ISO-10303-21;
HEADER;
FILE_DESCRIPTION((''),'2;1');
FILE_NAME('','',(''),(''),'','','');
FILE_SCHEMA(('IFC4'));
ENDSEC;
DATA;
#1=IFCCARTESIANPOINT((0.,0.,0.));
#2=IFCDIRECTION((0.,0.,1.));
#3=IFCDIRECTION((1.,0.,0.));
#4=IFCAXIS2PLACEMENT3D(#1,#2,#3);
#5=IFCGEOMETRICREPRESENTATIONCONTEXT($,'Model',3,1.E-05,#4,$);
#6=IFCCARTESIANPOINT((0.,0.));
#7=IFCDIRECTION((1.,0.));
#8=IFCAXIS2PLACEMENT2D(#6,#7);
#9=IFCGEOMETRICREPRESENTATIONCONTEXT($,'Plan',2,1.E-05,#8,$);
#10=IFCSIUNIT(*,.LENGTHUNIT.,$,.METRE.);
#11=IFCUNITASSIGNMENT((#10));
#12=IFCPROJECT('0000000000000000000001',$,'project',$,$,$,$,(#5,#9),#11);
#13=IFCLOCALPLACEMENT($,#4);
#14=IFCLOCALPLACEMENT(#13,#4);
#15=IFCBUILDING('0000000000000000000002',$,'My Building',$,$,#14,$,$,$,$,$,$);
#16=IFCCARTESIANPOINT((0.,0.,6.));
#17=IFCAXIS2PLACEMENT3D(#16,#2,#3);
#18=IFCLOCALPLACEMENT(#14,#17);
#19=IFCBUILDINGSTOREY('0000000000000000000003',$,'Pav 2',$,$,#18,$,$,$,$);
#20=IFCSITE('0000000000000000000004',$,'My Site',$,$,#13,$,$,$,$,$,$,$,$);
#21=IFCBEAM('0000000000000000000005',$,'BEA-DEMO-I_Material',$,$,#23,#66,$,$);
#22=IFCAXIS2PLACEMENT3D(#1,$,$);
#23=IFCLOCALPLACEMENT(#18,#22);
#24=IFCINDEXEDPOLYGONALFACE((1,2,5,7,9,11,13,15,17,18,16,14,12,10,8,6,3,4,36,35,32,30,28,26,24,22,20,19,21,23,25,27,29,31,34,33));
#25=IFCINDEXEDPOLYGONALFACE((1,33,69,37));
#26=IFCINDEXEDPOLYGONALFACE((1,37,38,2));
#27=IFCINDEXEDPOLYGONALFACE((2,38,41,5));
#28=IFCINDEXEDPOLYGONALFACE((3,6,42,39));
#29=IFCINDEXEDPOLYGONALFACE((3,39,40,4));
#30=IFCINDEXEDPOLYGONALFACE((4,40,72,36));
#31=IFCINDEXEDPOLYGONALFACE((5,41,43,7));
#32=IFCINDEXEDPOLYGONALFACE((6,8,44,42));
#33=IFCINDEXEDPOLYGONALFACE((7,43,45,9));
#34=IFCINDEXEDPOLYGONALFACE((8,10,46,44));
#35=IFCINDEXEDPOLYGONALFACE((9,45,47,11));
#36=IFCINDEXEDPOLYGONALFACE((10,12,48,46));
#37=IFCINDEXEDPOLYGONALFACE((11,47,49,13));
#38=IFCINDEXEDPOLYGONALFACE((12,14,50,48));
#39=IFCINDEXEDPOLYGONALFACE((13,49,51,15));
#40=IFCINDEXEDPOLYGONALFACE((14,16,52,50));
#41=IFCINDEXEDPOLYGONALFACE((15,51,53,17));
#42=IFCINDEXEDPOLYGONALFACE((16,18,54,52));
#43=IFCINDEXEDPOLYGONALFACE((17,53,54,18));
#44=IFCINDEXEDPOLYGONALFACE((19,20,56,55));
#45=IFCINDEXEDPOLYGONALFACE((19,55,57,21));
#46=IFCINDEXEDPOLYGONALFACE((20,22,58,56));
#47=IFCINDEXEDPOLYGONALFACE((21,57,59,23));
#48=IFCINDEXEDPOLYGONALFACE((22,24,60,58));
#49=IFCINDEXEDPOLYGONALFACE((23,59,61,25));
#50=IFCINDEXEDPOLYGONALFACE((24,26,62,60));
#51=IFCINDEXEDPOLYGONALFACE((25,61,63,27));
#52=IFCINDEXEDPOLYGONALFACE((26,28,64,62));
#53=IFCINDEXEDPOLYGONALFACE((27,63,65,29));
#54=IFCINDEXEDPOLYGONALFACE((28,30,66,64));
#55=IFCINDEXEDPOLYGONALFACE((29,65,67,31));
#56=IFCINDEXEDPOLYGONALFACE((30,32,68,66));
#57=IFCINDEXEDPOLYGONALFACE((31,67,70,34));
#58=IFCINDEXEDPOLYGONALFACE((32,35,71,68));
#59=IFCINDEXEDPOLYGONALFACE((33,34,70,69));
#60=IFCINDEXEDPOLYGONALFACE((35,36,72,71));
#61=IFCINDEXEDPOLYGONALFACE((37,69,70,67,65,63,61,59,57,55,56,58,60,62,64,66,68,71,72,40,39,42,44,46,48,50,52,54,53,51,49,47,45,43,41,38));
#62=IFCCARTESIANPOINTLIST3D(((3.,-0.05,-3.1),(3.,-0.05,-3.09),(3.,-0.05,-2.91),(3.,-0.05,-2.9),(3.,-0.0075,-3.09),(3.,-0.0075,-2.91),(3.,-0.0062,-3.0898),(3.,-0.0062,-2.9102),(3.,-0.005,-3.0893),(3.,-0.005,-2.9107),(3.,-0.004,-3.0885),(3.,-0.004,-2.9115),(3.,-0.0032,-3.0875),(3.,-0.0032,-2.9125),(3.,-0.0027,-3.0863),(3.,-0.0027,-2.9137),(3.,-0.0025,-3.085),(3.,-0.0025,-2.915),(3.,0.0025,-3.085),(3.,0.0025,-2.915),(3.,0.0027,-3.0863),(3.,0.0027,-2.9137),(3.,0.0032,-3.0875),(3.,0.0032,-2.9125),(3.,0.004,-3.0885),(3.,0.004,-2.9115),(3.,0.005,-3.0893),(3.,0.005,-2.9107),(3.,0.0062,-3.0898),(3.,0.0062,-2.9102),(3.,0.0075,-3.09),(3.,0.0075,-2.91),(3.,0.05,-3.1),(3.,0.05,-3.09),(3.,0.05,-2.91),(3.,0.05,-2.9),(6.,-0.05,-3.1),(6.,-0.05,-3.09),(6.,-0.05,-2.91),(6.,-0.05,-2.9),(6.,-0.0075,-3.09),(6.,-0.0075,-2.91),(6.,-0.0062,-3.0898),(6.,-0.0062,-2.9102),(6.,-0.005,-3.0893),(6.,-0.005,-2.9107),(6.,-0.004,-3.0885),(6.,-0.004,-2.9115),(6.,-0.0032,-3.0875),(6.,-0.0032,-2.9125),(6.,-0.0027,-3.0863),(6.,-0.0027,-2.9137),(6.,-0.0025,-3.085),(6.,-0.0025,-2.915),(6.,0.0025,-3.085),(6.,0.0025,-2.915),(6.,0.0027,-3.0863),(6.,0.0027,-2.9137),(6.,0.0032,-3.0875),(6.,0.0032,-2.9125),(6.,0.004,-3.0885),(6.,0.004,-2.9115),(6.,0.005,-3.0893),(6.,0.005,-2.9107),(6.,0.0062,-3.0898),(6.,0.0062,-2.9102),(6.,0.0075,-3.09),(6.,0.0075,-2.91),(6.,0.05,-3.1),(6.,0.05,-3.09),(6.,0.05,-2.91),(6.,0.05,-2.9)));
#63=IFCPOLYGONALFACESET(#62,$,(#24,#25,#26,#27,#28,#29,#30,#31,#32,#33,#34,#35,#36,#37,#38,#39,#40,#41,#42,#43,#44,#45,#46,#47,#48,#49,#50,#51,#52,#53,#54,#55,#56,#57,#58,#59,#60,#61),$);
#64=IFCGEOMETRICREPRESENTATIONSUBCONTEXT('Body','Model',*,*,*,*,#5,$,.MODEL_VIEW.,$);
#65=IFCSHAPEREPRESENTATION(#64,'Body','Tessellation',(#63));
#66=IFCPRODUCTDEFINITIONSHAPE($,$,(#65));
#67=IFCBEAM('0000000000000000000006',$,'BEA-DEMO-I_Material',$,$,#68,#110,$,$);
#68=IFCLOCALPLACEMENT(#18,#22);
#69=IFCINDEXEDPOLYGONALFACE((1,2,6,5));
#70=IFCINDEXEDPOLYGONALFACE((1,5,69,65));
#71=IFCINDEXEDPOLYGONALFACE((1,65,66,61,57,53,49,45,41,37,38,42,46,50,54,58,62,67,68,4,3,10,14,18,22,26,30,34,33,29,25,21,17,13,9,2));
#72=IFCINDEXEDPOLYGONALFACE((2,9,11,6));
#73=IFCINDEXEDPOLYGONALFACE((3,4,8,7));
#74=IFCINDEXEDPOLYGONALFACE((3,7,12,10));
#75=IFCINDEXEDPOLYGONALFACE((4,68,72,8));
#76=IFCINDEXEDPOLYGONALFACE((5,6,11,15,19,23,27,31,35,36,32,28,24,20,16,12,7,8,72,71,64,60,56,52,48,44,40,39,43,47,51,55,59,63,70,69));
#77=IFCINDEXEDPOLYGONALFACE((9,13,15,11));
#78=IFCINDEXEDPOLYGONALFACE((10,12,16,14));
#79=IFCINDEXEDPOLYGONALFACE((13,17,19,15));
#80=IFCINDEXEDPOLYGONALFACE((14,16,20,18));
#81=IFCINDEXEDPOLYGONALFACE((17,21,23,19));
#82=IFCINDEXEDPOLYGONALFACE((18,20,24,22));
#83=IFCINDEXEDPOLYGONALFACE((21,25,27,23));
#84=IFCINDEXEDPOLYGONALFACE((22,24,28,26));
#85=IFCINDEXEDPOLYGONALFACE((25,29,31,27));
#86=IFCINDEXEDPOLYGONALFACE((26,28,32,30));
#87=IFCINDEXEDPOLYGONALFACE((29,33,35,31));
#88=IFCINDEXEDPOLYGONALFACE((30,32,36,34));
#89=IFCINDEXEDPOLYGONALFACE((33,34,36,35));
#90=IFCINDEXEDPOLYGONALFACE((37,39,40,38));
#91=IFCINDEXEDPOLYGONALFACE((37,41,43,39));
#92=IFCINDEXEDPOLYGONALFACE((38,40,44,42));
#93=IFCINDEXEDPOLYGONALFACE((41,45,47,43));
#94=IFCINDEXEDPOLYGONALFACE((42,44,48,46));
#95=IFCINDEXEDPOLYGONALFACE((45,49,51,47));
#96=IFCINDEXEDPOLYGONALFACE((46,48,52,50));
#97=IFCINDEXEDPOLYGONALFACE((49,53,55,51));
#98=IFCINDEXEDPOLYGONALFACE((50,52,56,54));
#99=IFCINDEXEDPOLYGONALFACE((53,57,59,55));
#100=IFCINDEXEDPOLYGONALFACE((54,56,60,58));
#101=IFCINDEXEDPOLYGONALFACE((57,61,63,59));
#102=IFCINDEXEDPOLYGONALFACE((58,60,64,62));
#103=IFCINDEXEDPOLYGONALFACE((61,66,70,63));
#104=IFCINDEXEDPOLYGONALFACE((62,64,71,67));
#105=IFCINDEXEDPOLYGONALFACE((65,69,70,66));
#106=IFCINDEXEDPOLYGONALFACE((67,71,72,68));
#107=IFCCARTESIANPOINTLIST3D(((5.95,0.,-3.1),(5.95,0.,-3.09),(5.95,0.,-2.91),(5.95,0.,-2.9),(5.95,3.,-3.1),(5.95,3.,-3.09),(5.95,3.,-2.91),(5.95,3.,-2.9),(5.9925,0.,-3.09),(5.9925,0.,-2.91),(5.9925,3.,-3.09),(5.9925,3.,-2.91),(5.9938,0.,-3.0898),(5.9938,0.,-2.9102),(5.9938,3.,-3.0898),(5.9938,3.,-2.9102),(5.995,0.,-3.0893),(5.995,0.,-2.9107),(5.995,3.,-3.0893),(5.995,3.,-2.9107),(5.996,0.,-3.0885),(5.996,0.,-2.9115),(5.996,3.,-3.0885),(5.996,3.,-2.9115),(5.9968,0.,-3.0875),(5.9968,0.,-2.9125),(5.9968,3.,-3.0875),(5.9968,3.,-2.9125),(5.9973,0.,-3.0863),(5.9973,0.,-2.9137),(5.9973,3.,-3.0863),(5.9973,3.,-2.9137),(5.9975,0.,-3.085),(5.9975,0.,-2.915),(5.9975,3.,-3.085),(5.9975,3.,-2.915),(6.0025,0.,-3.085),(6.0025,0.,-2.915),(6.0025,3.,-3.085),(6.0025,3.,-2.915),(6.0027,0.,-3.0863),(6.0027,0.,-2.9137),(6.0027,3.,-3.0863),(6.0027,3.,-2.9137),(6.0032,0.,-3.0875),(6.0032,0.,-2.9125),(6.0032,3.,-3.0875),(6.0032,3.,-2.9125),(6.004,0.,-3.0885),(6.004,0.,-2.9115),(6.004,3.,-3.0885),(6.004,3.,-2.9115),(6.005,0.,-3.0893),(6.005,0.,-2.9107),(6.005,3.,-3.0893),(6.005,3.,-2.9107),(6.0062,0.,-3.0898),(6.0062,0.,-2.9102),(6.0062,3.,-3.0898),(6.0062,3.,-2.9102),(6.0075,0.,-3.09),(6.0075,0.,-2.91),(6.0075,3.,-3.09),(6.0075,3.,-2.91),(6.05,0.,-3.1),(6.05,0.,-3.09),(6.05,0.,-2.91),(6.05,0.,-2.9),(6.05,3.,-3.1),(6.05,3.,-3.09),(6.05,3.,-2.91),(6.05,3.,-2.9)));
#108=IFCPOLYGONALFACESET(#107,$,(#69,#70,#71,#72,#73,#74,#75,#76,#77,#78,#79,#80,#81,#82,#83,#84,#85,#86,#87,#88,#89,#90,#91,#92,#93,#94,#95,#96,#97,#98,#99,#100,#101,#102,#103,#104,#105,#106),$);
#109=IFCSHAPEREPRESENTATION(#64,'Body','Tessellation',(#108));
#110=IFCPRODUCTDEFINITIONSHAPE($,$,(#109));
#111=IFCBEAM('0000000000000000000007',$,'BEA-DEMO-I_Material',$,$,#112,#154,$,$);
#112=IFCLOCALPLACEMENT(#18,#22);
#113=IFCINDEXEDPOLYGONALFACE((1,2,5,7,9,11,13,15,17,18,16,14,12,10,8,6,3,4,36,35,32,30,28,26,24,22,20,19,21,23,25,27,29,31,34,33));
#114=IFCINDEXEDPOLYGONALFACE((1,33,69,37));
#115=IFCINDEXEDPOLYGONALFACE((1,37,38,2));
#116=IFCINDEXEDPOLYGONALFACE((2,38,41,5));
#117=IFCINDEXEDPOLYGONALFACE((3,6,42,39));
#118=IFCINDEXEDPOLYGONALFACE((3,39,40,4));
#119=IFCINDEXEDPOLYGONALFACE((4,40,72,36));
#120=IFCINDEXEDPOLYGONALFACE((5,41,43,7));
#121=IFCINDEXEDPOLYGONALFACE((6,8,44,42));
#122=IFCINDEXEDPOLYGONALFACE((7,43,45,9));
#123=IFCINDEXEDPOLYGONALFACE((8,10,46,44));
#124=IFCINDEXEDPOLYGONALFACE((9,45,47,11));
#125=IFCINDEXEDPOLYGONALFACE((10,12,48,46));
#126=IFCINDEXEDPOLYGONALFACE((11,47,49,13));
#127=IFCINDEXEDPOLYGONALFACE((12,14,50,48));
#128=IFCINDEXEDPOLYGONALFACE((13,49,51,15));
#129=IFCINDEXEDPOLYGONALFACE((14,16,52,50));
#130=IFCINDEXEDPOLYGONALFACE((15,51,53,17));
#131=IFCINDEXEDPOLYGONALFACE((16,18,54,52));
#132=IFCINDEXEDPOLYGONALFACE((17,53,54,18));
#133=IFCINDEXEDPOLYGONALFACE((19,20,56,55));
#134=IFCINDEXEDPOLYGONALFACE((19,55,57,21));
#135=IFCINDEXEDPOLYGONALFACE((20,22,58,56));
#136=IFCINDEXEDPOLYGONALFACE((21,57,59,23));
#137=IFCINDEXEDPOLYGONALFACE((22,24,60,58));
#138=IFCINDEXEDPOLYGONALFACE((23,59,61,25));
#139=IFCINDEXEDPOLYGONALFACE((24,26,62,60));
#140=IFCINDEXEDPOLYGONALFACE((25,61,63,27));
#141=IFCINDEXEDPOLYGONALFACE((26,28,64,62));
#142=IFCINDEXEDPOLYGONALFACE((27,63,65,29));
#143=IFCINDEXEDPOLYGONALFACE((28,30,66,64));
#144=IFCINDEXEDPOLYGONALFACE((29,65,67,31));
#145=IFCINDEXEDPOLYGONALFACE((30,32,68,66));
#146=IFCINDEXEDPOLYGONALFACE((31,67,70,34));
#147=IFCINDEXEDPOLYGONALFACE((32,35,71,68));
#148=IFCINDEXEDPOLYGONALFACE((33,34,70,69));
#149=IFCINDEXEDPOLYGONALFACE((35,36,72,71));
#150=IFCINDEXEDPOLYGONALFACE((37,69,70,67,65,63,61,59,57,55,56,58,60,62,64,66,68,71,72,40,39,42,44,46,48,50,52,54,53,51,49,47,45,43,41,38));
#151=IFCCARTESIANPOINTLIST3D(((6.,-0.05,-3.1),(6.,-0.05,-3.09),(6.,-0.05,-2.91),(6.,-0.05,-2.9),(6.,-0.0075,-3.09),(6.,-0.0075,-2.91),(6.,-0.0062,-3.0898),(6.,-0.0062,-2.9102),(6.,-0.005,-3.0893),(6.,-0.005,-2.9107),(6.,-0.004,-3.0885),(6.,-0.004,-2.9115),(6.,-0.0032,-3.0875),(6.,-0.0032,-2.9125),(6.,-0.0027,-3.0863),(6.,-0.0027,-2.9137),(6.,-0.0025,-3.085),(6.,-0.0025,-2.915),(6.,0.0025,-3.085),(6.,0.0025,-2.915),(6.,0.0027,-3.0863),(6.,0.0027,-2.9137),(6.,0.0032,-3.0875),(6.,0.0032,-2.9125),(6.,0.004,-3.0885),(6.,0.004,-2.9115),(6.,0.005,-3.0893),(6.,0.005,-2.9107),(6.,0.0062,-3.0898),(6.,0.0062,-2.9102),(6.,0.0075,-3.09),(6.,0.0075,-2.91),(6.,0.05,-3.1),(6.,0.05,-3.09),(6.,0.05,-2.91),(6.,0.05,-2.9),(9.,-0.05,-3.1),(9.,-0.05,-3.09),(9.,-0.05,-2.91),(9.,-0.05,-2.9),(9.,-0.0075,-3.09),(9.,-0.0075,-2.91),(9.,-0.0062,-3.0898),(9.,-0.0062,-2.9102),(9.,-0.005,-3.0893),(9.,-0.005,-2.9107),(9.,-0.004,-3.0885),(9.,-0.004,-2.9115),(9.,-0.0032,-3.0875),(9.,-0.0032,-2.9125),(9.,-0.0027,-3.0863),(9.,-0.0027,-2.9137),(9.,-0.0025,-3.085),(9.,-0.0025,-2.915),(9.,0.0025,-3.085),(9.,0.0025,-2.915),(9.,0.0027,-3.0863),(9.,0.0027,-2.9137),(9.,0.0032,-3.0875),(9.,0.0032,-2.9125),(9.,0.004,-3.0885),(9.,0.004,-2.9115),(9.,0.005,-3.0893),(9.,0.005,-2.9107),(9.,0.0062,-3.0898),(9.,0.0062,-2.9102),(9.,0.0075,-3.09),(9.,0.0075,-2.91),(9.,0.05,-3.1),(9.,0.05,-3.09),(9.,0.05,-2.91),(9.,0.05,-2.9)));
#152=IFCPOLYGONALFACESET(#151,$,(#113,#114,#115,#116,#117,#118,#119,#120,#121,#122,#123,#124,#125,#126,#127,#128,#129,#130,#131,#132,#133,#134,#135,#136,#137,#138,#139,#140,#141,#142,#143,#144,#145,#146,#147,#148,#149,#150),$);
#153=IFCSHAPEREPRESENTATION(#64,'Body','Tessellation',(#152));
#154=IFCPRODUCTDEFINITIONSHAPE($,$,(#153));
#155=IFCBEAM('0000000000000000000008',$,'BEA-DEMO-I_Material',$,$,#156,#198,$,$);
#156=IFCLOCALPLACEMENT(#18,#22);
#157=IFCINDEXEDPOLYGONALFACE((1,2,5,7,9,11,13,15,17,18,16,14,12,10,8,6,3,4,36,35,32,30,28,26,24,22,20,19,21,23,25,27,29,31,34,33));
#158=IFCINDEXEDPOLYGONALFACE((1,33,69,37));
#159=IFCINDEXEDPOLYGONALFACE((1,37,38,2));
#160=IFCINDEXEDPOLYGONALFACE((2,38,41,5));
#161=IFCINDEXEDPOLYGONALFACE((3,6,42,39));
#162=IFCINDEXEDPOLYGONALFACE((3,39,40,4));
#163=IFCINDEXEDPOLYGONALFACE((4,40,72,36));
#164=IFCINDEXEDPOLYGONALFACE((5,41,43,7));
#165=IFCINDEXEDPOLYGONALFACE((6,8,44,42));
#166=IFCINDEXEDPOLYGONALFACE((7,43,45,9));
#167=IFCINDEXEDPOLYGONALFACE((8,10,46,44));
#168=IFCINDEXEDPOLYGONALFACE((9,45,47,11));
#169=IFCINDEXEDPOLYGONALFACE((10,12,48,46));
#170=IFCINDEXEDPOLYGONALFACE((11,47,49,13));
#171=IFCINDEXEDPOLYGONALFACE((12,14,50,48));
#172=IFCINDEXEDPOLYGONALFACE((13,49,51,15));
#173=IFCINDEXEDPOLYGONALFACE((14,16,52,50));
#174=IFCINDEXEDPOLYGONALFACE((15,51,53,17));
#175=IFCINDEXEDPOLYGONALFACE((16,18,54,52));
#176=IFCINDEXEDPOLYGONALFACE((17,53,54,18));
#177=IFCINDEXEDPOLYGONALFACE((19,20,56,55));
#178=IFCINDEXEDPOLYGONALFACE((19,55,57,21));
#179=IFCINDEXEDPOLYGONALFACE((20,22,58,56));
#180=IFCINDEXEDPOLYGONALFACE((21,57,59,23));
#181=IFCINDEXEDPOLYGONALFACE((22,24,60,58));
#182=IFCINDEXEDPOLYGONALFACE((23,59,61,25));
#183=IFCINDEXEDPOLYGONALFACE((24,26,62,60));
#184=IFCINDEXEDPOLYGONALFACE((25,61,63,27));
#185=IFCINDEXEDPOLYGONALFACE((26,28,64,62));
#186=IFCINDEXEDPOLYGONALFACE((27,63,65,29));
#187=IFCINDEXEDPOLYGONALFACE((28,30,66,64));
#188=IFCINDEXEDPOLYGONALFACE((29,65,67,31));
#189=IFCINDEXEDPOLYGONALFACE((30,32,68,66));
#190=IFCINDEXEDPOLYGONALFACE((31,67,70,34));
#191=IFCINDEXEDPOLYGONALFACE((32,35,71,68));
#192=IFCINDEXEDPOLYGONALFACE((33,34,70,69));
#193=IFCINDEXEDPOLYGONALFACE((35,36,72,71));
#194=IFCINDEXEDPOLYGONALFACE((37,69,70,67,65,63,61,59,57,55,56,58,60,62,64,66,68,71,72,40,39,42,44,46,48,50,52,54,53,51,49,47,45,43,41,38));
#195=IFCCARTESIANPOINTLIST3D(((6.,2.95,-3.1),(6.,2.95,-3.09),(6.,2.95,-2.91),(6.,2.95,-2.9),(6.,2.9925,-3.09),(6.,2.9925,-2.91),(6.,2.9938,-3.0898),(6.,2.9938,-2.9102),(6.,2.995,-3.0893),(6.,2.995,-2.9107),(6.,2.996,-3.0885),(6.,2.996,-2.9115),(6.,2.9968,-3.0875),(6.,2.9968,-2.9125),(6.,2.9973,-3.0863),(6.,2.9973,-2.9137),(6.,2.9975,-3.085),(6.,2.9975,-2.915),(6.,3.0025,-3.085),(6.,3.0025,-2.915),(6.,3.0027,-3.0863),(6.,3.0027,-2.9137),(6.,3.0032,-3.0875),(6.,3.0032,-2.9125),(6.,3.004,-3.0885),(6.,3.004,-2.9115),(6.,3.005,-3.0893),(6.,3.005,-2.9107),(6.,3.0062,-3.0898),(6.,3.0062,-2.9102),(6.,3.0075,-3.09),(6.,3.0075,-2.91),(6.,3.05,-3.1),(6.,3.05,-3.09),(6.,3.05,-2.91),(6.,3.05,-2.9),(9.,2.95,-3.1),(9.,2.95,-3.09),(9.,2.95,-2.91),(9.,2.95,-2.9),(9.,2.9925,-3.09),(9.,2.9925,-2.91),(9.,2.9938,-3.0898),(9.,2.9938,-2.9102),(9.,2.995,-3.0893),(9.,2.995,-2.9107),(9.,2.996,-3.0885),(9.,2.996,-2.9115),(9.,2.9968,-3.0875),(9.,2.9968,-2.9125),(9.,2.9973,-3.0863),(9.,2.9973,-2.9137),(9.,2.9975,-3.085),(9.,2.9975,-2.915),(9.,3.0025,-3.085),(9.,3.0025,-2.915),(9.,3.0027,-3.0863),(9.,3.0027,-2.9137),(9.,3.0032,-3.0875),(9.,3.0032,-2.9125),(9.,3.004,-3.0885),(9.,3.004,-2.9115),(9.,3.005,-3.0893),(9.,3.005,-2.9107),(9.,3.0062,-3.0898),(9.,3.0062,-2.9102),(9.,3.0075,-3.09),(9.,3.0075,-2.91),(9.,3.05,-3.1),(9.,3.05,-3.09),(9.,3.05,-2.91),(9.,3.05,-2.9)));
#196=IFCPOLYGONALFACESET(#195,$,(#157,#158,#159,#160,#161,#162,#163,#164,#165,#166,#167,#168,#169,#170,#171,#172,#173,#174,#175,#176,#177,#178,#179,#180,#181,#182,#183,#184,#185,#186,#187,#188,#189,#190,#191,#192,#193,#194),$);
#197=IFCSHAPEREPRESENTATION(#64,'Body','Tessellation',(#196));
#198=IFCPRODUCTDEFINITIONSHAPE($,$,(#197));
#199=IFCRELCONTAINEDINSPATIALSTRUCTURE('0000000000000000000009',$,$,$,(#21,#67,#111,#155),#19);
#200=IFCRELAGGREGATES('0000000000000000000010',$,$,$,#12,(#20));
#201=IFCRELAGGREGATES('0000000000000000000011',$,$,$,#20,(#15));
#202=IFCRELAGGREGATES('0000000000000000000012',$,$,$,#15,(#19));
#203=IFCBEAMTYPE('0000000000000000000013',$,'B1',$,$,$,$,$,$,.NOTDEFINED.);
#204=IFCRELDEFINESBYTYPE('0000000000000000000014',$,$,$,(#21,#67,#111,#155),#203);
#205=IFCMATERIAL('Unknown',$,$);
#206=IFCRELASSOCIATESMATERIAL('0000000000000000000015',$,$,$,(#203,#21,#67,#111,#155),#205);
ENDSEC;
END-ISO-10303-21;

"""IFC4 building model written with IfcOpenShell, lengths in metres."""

from ifc_helpers import new_model, si_unit, frame, origin, origin_with_axes, origin_2d_with_axis, place, context, subcontext, project, spatial, i_section, extrude, material, material_profile, profile_set, profile_usage, type_object, element, save


model = new_model("IFC4")

# Units and contexts
model_context = context("Model", 3, precision=1e-05, world=origin_with_axes())
plan_context = context("Plan", 2, precision=1e-05, world=origin_2d_with_axis())
body_context = subcontext(model_context, "Body", "Model", "MODEL_VIEW")
ifc_project = project(units=[si_unit("LENGTHUNIT", "METRE")], contexts=[model_context, plan_context])

# Site, building, storey
site_placement = place(None, origin_with_axes())
site = spatial("IfcSite", under=ifc_project, at=site_placement, Name="My Site")
building_placement = place(site_placement, origin_with_axes())
building = spatial("IfcBuilding", under=site, at=building_placement, Name="My Building")
storey_placement = place(building_placement, frame((0.0, 0.0, 6.0), z_axis=(0.0, 0.0, 1.0), x_axis=(1.0, 0.0, 0.0)))
storey = spatial("IfcBuildingStorey", under=building, at=storey_placement, Name="Pav 2")

# Beams
ifc_material = material(Name="Unknown")
ifc_material_profile = material_profile(ifc_material, i_section(OverallWidth=0.1, OverallDepth=0.2, WebThickness=0.005, FlangeThickness=0.01, FilletRadius=0.005))
ifc_profile_set = profile_set([ifc_material_profile])
ifc_profile_usage_1 = profile_usage(ifc_profile_set, cardinal=5)
beam_type = type_object("IfcBeamType", Name="B1", PredefinedType="NOTDEFINED", material=ifc_profile_set)
beam_1_placement = place(storey_placement, frame((6.0, 0.0, -3.0), z_axis=(-1.0, 0.0, 0.0), x_axis=(0.0, -1.0, 0.0)))
element("IfcBeam", 1, at=beam_1_placement, inside=storey, type_object=beam_type, material=ifc_profile_usage_1, Name="BEA-DEMO-I_Material", context=body_context, shape_type="SweptSolid", body=[
    extrude(i_section(OverallWidth=0.1, OverallDepth=0.2, WebThickness=0.005, FlangeThickness=0.01, FilletRadius=0.005), origin(), (0.0, 0.0, 1.0), 3.0),
])
ifc_profile_usage_2 = profile_usage(ifc_profile_set, cardinal=5)
beam_2_placement = place(storey_placement, frame((6.0, 3.0, -3.0), z_axis=(0.0, -1.0, 0.0), x_axis=(1.0, 0.0, 0.0)))
element("IfcBeam", 2, at=beam_2_placement, inside=storey, type_object=beam_type, material=ifc_profile_usage_2, Name="BEA-DEMO-I_Material", context=body_context, shape_type="SweptSolid", body=[
    extrude(i_section(OverallWidth=0.1, OverallDepth=0.2, WebThickness=0.005, FlangeThickness=0.01, FilletRadius=0.005), origin(), (0.0, 0.0, 1.0), 3.0),
])
ifc_profile_usage_3 = profile_usage(ifc_profile_set, cardinal=5)
beam_3_placement = place(storey_placement, frame((9.0, 0.0, -3.0), z_axis=(-1.0, 0.0, 0.0), x_axis=(0.0, -1.0, 0.0)))
element("IfcBeam", 3, at=beam_3_placement, inside=storey, type_object=beam_type, material=ifc_profile_usage_3, Name="BEA-DEMO-I_Material", context=body_context, shape_type="SweptSolid", body=[
    extrude(i_section(OverallWidth=0.1, OverallDepth=0.2, WebThickness=0.005, FlangeThickness=0.01, FilletRadius=0.005), origin(), (0.0, 0.0, 1.0), 3.0),
])
ifc_profile_usage_4 = profile_usage(ifc_profile_set, cardinal=5)
beam_4_placement = place(storey_placement, frame((6.0, 3.0, -3.0), z_axis=(1.0, 0.0, 0.0), x_axis=(0.0, 1.0, 0.0)))
element("IfcBeam", 4, at=beam_4_placement, inside=storey, type_object=beam_type, material=ifc_profile_usage_4, Name="BEA-DEMO-I_Material", context=body_context, shape_type="SweptSolid", body=[
    extrude(i_section(OverallWidth=0.1, OverallDepth=0.2, WebThickness=0.005, FlangeThickness=0.01, FilletRadius=0.005), origin(), (0.0, 0.0, 1.0), 3.0),
])

save(model, "model.ifc")
